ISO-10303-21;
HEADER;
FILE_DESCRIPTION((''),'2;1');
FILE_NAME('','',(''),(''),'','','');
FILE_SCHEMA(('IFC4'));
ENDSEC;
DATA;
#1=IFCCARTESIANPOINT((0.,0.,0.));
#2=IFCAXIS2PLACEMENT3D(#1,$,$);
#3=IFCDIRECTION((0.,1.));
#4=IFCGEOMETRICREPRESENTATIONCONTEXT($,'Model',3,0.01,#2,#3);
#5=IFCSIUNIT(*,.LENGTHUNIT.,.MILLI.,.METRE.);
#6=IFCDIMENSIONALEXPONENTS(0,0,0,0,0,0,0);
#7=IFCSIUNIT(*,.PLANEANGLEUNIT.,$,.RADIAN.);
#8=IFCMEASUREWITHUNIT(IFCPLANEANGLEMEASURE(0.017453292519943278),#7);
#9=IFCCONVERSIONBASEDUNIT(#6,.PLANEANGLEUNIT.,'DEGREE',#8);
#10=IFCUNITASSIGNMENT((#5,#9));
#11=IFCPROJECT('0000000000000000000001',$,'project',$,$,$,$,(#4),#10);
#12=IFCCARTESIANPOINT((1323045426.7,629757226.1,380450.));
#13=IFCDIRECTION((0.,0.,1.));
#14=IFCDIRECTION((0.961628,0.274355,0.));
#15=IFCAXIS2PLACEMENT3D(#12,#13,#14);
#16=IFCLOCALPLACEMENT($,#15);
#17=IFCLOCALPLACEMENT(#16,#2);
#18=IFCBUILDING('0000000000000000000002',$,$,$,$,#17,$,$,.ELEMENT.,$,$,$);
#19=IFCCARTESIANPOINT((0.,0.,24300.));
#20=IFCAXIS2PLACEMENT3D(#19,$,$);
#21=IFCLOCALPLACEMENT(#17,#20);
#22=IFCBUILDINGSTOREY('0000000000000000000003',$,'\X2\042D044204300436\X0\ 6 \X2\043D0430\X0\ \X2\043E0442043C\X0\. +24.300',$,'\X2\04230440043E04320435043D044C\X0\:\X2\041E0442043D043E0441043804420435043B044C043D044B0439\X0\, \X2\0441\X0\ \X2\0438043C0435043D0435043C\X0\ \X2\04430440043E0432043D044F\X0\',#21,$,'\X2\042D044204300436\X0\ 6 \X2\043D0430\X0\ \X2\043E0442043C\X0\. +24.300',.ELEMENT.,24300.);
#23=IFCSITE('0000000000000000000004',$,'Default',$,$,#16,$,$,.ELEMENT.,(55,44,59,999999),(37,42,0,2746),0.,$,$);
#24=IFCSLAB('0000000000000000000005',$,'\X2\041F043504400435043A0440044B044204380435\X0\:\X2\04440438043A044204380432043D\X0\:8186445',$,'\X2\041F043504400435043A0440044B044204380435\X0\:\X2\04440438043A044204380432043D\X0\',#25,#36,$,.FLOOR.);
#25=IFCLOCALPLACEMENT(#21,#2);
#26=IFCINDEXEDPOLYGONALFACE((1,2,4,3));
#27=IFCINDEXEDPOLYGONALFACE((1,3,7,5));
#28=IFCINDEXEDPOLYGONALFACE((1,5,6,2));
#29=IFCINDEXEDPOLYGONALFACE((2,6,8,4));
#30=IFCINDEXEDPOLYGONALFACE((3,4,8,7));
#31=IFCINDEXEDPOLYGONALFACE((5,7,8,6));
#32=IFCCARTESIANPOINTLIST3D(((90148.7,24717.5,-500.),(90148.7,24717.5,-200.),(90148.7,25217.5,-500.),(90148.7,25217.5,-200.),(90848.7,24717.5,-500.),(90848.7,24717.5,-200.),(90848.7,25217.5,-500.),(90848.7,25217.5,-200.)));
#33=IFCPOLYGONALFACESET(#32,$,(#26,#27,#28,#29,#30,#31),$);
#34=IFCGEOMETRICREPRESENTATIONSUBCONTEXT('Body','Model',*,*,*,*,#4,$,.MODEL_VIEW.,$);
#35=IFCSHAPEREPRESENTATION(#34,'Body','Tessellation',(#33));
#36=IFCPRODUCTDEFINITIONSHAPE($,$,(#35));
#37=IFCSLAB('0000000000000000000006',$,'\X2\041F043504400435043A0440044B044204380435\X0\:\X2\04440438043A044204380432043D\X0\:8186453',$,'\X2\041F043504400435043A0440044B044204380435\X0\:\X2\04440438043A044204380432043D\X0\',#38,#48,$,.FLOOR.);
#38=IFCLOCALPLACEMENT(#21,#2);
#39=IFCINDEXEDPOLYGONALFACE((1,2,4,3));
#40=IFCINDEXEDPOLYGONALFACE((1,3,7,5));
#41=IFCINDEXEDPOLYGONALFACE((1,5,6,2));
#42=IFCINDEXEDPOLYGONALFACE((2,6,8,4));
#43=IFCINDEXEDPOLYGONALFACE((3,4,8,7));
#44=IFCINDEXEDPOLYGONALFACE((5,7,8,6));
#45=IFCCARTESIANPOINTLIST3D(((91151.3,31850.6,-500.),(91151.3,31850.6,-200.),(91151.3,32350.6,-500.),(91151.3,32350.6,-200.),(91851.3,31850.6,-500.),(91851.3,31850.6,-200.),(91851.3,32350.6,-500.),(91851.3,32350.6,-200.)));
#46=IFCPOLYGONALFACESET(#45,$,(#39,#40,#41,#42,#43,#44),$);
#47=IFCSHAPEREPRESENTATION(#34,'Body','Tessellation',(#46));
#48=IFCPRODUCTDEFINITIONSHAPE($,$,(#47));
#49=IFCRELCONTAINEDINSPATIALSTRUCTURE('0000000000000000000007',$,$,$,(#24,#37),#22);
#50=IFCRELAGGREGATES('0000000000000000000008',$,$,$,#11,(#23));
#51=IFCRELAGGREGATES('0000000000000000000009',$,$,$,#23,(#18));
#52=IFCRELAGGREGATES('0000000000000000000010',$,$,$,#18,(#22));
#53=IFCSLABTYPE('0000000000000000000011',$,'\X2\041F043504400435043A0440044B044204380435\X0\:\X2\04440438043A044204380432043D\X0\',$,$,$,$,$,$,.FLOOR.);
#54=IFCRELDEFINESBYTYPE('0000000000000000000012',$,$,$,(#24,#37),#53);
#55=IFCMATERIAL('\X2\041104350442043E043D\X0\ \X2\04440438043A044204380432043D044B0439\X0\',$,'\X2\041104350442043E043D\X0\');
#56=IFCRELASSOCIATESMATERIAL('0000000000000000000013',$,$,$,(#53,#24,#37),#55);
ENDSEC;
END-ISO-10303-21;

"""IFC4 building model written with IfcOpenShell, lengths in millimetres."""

from ifc_helpers import new_model, entity, si_unit, converted_unit, direction, frame, origin, place, context, subcontext, project, spatial, indexed_curve, outline, extrude, material, type_object, element, save


model = new_model("IFC4")

# Units and contexts
model_context = context("Model", 3, precision=0.01, world=origin(), true_north=direction((0.0, 1.0)))
body_context = subcontext(model_context, "Body", "Model", "MODEL_VIEW")
ifc_project = project(units=[si_unit("LENGTHUNIT", "METRE", prefix="MILLI"), converted_unit("PLANEANGLEUNIT", "DEGREE", entity("IfcPlaneAngleMeasure", 0.017453292519943278), si_unit("PLANEANGLEUNIT", "RADIAN"), dimensions=[0, 0, 0, 0, 0, 0, 0])], contexts=[model_context])

# Site, building, storey
site_placement = place(None, frame((1323045426.7, 629757226.1, 380450.0), z_axis=(0.0, 0.0, 1.0), x_axis=(0.961628, 0.274355, 0.0)))
site = spatial("IfcSite", under=ifc_project, at=site_placement, Name="Default", CompositionType="ELEMENT", RefLatitude=(55, 44, 59, 999999), RefLongitude=(37, 42, 0, 2746), RefElevation=0.0)
building_placement = place(site_placement, origin())
building = spatial("IfcBuilding", under=site, at=building_placement, CompositionType="ELEMENT")
storey_placement = place(building_placement, frame((0.0, 0.0, 24300.0)))
storey = spatial("IfcBuildingStorey", under=building, at=storey_placement, Name="Этаж 6 на отм. +24.300", ObjectType="Уровень:Относительный, с именем уровня", LongName="Этаж 6 на отм. +24.300", CompositionType="ELEMENT", Elevation=24300.0)

# Slabs
ifc_material_1 = material(Name="Бетон фиктивный", Category="Бетон")
slab_type_1 = type_object("IfcSlabType", Name="Перекрытие:фиктивн", PredefinedType="FLOOR", material=ifc_material_1)
slab_1_placement = place(storey_placement, origin())
element("IfcSlab", 1, at=slab_1_placement, inside=storey, type_object=slab_type_1, material=ifc_material_1, Name="Перекрытие:фиктивн:8186445", ObjectType="Перекрытие:фиктивн", PredefinedType="FLOOR", context=body_context, shape_type="SweptSolid", body=[
    extrude(outline(indexed_curve([(-250.0, -350.0), (250.0, -350.0), (250.0, 350.0), (-250.0, 350.0), (-250.0, -350.0)], self_intersect=False)), frame((90498.7, 24967.5, -200.0), z_axis=(0.0, 0.0, -1.0), x_axis=(0.0, 1.0, 0.0)), (0.0, 0.0, 1.0), 300.0),
])
slab_2_placement = place(storey_placement, origin())
element("IfcSlab", 2, at=slab_2_placement, inside=storey, type_object=slab_type_1, material=ifc_material_1, Name="Перекрытие:фиктивн:8186453", ObjectType="Перекрытие:фиктивн", PredefinedType="FLOOR", context=body_context, shape_type="SweptSolid", body=[
    extrude(outline(indexed_curve([(-250.0, -350.0), (250.0, -350.0), (250.0, 350.0), (-250.0, 350.0), (-250.0, -350.0)], self_intersect=False)), frame((91501.3, 32100.6, -200.0), z_axis=(0.0, 0.0, -1.0), x_axis=(0.0, 1.0, 0.0)), (0.0, 0.0, 1.0), 300.0),
])

save(model, "model.ifc")
